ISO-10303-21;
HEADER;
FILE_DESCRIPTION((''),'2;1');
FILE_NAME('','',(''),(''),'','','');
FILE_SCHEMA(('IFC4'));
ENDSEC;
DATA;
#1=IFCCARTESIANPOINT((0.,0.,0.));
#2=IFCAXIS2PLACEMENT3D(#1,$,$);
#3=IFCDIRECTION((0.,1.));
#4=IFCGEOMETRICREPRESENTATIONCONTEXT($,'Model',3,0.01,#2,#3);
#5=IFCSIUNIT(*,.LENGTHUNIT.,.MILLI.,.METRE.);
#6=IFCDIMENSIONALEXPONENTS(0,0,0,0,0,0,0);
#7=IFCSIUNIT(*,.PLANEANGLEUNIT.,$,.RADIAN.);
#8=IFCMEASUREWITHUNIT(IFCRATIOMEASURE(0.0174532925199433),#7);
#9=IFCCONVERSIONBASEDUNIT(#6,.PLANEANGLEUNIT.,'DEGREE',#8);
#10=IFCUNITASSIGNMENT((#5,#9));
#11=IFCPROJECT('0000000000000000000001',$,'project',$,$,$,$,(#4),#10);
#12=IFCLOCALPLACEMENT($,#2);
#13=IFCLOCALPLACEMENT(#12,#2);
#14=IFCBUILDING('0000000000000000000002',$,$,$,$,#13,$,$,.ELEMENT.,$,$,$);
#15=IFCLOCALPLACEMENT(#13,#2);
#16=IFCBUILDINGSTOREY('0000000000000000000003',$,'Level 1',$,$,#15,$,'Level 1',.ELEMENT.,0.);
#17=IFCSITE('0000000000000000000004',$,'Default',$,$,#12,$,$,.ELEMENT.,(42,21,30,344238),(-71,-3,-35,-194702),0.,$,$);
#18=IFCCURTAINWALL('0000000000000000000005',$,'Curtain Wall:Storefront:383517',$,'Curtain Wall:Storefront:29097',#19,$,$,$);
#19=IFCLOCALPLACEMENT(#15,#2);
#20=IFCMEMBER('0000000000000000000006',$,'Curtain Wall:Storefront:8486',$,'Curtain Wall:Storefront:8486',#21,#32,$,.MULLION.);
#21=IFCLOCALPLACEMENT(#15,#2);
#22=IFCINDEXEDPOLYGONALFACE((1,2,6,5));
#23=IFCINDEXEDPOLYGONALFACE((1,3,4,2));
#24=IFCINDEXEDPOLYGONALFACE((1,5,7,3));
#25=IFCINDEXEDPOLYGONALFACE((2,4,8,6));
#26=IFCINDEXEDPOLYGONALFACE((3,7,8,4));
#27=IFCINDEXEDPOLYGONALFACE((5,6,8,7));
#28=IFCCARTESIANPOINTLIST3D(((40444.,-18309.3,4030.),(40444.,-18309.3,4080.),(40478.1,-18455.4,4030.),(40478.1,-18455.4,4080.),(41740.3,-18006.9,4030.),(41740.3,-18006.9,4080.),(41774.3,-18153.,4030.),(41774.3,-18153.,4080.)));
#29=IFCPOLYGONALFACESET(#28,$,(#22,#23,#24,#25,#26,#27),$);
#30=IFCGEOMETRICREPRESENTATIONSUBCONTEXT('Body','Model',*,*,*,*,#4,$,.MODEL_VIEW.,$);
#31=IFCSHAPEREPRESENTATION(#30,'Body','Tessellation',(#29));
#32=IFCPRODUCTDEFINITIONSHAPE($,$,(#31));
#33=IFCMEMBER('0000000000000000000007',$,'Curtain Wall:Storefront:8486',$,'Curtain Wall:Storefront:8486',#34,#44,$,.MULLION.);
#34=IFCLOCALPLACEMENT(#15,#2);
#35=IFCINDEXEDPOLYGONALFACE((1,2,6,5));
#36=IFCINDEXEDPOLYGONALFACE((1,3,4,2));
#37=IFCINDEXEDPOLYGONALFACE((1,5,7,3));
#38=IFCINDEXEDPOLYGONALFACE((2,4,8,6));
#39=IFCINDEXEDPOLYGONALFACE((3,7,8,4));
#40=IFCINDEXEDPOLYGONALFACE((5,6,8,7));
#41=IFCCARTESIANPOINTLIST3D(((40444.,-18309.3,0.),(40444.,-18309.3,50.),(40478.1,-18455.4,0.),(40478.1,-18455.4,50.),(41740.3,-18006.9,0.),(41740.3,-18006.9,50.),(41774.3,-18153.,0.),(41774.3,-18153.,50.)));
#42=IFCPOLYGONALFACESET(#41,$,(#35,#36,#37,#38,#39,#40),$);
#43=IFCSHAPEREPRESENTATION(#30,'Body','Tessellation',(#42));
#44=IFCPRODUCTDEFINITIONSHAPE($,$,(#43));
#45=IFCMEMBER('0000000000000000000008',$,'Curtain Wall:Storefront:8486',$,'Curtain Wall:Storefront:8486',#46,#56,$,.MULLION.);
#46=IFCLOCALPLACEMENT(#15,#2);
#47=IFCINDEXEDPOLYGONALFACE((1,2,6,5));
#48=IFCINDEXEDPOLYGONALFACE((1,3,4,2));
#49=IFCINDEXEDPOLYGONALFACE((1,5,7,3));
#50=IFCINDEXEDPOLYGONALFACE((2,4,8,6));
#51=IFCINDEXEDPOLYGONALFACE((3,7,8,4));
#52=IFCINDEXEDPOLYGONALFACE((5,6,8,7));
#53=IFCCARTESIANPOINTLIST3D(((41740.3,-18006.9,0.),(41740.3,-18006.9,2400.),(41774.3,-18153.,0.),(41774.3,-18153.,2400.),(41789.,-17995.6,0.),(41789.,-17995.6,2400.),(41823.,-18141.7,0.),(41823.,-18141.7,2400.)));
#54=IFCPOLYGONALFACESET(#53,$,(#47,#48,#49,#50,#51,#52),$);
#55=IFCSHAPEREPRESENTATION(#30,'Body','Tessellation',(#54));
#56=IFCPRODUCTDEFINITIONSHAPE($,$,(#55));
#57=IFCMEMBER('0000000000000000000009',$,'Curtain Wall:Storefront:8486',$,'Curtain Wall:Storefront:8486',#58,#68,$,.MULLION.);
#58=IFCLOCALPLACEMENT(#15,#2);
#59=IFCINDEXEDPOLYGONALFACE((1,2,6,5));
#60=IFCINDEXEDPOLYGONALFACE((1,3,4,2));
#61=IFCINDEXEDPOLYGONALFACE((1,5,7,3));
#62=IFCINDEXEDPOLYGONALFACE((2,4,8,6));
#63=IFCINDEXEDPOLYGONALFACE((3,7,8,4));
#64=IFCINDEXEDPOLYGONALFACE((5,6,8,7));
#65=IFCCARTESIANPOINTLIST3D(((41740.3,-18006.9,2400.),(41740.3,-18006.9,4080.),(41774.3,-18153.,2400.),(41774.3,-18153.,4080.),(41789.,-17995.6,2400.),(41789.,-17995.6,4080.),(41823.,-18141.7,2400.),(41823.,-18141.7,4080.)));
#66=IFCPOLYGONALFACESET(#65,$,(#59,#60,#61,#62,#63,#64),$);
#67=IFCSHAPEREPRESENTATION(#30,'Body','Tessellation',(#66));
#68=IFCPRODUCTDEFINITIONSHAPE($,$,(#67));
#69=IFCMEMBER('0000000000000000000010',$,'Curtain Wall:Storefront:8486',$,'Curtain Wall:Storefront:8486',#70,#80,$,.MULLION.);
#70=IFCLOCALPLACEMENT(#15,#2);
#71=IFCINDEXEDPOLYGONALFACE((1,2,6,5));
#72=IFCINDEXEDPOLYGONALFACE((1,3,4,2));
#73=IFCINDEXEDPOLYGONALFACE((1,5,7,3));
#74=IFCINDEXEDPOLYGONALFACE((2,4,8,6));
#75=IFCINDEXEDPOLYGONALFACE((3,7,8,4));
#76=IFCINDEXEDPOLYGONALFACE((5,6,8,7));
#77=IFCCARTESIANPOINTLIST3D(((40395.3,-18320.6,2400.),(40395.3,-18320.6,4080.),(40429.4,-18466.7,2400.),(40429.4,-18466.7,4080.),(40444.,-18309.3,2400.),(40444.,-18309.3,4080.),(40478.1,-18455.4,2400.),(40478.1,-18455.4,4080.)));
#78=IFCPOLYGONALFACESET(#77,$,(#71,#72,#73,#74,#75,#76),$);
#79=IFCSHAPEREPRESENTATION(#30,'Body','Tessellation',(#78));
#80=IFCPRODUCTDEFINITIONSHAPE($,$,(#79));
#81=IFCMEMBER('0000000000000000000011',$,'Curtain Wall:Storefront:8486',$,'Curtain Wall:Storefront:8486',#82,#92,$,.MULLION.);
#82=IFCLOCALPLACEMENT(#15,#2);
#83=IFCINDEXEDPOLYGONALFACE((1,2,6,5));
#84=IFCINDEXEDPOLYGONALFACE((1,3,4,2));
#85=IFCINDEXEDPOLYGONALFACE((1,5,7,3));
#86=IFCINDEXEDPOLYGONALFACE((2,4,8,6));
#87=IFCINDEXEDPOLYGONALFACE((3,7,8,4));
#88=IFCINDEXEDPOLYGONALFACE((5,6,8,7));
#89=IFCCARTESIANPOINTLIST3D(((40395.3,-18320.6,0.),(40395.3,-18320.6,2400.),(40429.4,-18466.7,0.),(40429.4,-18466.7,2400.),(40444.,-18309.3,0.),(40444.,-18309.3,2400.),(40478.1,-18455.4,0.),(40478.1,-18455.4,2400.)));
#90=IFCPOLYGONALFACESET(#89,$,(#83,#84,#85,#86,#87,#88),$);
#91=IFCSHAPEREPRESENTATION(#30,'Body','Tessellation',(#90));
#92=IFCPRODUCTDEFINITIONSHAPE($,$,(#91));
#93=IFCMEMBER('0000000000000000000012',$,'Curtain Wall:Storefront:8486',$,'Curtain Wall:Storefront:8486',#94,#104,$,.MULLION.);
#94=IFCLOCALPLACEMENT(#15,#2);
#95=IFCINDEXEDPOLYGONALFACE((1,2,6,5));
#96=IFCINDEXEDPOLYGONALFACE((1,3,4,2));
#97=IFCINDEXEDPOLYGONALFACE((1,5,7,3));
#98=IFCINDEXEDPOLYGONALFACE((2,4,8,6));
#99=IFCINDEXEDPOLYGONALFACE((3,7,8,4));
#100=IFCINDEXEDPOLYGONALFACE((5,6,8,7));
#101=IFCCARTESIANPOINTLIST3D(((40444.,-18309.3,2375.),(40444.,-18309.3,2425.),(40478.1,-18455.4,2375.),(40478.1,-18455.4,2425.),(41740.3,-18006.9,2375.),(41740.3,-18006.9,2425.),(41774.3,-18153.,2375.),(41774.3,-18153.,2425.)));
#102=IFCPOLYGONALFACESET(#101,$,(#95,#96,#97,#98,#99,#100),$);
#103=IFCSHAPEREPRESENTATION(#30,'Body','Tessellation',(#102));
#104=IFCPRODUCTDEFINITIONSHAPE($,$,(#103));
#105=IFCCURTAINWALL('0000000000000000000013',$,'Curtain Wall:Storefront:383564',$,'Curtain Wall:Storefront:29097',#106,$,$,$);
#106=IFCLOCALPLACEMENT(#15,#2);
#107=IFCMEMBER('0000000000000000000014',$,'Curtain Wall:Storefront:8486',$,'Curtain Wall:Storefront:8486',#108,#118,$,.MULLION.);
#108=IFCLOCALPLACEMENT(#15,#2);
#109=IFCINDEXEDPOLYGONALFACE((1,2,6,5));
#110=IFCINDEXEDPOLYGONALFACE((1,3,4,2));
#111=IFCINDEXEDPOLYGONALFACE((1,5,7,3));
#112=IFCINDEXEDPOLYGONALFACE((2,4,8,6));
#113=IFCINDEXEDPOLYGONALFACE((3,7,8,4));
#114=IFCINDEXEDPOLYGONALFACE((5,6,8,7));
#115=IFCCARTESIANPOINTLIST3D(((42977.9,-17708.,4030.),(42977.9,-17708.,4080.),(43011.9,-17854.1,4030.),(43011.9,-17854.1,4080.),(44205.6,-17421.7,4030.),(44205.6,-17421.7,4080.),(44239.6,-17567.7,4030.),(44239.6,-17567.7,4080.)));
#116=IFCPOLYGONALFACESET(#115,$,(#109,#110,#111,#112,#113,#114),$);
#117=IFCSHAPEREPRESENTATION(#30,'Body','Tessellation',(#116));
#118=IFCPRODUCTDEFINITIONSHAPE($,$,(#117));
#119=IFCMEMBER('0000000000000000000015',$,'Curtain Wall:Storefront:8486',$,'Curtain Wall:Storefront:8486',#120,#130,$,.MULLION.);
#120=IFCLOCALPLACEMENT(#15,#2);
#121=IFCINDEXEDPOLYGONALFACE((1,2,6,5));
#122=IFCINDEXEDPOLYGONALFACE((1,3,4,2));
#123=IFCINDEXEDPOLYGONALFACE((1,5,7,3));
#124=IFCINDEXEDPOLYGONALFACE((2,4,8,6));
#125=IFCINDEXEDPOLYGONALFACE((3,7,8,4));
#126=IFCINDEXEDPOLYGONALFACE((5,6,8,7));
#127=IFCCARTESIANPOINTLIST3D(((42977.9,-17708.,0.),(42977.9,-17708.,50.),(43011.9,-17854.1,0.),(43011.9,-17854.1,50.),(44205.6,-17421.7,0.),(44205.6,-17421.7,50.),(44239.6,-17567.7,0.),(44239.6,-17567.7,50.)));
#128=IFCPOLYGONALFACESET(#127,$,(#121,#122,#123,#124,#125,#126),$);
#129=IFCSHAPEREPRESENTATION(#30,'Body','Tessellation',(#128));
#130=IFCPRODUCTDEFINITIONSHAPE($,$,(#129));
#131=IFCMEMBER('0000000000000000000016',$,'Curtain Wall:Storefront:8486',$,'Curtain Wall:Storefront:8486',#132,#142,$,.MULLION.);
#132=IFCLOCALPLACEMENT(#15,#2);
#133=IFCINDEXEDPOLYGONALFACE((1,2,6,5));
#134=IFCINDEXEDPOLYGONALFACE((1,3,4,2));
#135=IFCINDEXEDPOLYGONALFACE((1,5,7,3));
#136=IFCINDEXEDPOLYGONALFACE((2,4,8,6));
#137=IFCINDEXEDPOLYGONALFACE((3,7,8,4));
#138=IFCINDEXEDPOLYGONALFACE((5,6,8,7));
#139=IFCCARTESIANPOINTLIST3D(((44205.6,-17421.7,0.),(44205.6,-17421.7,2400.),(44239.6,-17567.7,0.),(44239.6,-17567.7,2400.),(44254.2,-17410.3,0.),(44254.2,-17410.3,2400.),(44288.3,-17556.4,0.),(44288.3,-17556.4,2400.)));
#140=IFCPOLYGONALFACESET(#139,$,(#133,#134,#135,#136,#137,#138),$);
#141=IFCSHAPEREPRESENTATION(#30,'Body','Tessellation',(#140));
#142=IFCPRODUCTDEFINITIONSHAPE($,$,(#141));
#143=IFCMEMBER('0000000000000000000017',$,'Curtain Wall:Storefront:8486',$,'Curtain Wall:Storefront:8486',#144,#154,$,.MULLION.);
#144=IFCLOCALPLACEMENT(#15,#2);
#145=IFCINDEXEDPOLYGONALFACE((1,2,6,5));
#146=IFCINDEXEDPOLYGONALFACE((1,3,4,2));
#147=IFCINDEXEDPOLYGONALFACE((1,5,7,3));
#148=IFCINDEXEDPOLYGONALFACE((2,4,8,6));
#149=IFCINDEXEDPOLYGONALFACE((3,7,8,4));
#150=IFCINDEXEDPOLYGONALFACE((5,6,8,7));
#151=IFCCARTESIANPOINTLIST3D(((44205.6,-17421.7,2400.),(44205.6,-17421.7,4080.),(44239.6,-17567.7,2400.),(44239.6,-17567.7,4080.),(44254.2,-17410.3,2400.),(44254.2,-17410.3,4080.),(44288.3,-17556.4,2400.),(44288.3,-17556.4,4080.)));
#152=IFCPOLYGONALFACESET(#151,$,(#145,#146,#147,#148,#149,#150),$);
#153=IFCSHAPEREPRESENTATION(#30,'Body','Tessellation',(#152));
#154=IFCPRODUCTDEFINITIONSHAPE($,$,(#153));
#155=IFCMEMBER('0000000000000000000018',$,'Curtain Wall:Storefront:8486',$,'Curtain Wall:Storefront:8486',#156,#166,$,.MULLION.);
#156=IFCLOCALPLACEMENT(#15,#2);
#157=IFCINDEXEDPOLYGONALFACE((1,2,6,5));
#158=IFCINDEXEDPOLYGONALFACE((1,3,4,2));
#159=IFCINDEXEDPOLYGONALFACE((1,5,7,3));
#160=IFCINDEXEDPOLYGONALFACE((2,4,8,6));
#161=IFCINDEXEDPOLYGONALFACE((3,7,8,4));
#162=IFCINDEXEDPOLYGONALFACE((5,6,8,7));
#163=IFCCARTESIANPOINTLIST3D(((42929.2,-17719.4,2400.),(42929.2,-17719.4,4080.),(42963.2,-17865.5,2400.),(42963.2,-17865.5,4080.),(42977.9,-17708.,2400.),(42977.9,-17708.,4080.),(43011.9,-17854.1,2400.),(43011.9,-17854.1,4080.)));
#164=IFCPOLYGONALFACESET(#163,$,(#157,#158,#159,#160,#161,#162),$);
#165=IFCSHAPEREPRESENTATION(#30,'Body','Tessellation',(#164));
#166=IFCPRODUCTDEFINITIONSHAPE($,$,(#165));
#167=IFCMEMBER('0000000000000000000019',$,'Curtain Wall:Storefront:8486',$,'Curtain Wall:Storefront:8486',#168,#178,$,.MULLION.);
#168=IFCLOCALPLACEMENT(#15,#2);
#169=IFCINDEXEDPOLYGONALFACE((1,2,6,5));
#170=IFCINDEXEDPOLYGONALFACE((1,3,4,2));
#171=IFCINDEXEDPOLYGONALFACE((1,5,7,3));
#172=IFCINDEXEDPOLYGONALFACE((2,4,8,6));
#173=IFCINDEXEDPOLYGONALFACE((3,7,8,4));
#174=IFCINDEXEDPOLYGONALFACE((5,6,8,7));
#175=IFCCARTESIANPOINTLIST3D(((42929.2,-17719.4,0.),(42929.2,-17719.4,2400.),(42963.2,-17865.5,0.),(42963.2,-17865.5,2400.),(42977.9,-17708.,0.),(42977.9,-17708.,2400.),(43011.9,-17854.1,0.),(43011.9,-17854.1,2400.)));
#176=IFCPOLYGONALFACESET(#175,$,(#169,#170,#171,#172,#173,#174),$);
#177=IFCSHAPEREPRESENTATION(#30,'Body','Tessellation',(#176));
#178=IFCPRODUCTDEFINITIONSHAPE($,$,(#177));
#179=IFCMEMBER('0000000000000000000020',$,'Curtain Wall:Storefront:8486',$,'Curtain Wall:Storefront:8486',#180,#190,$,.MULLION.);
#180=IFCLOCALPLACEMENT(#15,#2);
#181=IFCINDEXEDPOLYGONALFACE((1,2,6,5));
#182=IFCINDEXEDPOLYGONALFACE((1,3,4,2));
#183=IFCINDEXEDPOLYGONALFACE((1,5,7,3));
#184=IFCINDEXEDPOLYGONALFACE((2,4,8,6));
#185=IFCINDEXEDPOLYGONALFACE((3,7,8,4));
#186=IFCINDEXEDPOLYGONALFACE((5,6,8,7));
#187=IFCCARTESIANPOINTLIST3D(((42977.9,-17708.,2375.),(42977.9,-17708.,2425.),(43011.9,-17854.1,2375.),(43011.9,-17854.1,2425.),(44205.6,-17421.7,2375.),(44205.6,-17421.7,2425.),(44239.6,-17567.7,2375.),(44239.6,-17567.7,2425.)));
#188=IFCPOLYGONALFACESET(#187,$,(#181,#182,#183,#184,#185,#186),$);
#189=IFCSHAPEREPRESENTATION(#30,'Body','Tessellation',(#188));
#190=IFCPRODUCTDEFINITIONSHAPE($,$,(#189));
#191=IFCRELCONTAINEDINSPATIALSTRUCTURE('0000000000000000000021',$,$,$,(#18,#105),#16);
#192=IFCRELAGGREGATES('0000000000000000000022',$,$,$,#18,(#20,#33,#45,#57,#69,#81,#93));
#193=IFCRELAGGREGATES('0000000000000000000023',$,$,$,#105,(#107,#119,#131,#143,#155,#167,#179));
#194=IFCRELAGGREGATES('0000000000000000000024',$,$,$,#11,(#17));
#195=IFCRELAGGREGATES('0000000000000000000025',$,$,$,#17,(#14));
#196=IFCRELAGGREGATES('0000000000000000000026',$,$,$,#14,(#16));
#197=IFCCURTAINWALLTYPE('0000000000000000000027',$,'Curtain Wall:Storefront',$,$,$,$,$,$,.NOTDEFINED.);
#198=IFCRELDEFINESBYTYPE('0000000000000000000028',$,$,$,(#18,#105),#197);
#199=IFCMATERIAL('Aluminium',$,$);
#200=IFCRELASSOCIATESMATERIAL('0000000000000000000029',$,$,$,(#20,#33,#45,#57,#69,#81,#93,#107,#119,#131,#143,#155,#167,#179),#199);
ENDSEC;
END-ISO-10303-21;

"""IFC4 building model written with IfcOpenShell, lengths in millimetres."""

from ifc_helpers import new_model, entity, si_unit, converted_unit, direction, frame, frame_2d, origin, place, context, subcontext, project, spatial, rectangle, extrude, material, type_object, element, aggregate, save


model = new_model("IFC4")

# Units and contexts
model_context = context("Model", 3, precision=0.01, world=origin(), true_north=direction((0.0, 1.0)))
body_context = subcontext(model_context, "Body", "Model", "MODEL_VIEW")
ifc_project = project(units=[si_unit("LENGTHUNIT", "METRE", prefix="MILLI"), converted_unit("PLANEANGLEUNIT", "DEGREE", entity("IfcRatioMeasure", 0.0174532925199433), si_unit("PLANEANGLEUNIT", "RADIAN"), dimensions=[0, 0, 0, 0, 0, 0, 0])], contexts=[model_context])

# Site, building, storey
site_placement = place(None, origin())
site = spatial("IfcSite", under=ifc_project, at=site_placement, Name="Default", CompositionType="ELEMENT", RefLatitude=(42, 21, 30, 344238), RefLongitude=(-71, -3, -35, -194702), RefElevation=0.0)
building_placement = place(site_placement, origin())
building = spatial("IfcBuilding", under=site, at=building_placement, CompositionType="ELEMENT")
storey_placement = place(building_placement, origin())
storey = spatial("IfcBuildingStorey", under=building, at=storey_placement, Name="Level 1", LongName="Level 1", CompositionType="ELEMENT", Elevation=0.0)

# Curtain walls, members
curtain_wall_type = type_object("IfcCurtainWallType", Name="Curtain Wall:Storefront", PredefinedType="NOTDEFINED")
curtain_wall_1_placement = place(storey_placement, origin())
curtain_wall_1 = element("IfcCurtainWall", 1, at=curtain_wall_1_placement, inside=storey, type_object=curtain_wall_type, Name="Curtain Wall:Storefront:383517", ObjectType="Curtain Wall:Storefront:29097")
ifc_material = material(Name="Aluminium")
member_1_placement = place(curtain_wall_1_placement, origin())
member_1 = element("IfcMember", 2, at=member_1_placement, material=ifc_material, Name="Curtain Wall:Storefront:8486", ObjectType="Curtain Wall:Storefront:8486", PredefinedType="MULLION", context=body_context, shape_type="SweptSolid", body=[
    extrude(rectangle(XDim=50.0, YDim=150.0, at=frame_2d((0.0, 0.0), x_axis=(1.0, 0.0))), frame((41757.3, -18080.0, 4055.0), z_axis=(-0.973861, -0.227145, 0.0), x_axis=(0.0, 0.0, -1.0)), (0.0, 0.0, 1.0), 1331.1),
])
member_2_placement = place(curtain_wall_1_placement, origin())
member_2 = element("IfcMember", 3, at=member_2_placement, material=ifc_material, Name="Curtain Wall:Storefront:8486", ObjectType="Curtain Wall:Storefront:8486", PredefinedType="MULLION", context=body_context, shape_type="SweptSolid", body=[
    extrude(rectangle(XDim=50.0, YDim=150.0, at=frame_2d((0.0, 0.0), x_axis=(1.0, 0.0))), frame((40461.0, -18382.3, 25.0), z_axis=(0.973861, 0.227145, 0.0), x_axis=(0.0, 0.0, -1.0)), (0.0, 0.0, 1.0), 1331.1),
])
member_3_placement = place(curtain_wall_1_placement, origin())
member_3 = element("IfcMember", 4, at=member_3_placement, material=ifc_material, Name="Curtain Wall:Storefront:8486", ObjectType="Curtain Wall:Storefront:8486", PredefinedType="MULLION", context=body_context, shape_type="SweptSolid", body=[
    extrude(rectangle(XDim=50.0, YDim=150.0, at=frame_2d((0.0, 0.0), x_axis=(1.0, 0.0))), frame((41781.7, -18074.3, 0.0), z_axis=(0.0, 0.0, 1.0), x_axis=(0.973861, 0.227145, 0.0)), (0.0, 0.0, 1.0), 2400.0),
])
member_4_placement = place(curtain_wall_1_placement, origin())
member_4 = element("IfcMember", 5, at=member_4_placement, material=ifc_material, Name="Curtain Wall:Storefront:8486", ObjectType="Curtain Wall:Storefront:8486", PredefinedType="MULLION", context=body_context, shape_type="SweptSolid", body=[
    extrude(rectangle(XDim=50.0, YDim=150.0, at=frame_2d((0.0, 0.0), x_axis=(1.0, 0.0))), frame((41781.7, -18074.3, 2400.0), z_axis=(0.0, 0.0, 1.0), x_axis=(0.973861, 0.227145, 0.0)), (0.0, 0.0, 1.0), 1680.0),
])
member_5_placement = place(curtain_wall_1_placement, origin())
member_5 = element("IfcMember", 6, at=member_5_placement, material=ifc_material, Name="Curtain Wall:Storefront:8486", ObjectType="Curtain Wall:Storefront:8486", PredefinedType="MULLION", context=body_context, shape_type="SweptSolid", body=[
    extrude(rectangle(XDim=150.0, YDim=50.0, at=frame_2d((0.0, 0.0), x_axis=(1.0, 0.0))), frame((40436.7, -18388.0, 4080.0), z_axis=(0.0, 0.0, -1.0), x_axis=(0.227145, -0.973861, 0.0)), (0.0, 0.0, 1.0), 1680.0),
])
member_6_placement = place(curtain_wall_1_placement, origin())
member_6 = element("IfcMember", 7, at=member_6_placement, material=ifc_material, Name="Curtain Wall:Storefront:8486", ObjectType="Curtain Wall:Storefront:8486", PredefinedType="MULLION", context=body_context, shape_type="SweptSolid", body=[
    extrude(rectangle(XDim=150.0, YDim=50.0, at=frame_2d((0.0, 0.0), x_axis=(1.0, 0.0))), frame((40436.7, -18388.0, 2400.0), z_axis=(0.0, 0.0, -1.0), x_axis=(0.227145, -0.973861, 0.0)), (0.0, 0.0, 1.0), 2400.0),
])
member_7_placement = place(curtain_wall_1_placement, origin())
member_7 = element("IfcMember", 8, at=member_7_placement, material=ifc_material, Name="Curtain Wall:Storefront:8486", ObjectType="Curtain Wall:Storefront:8486", PredefinedType="MULLION", context=body_context, shape_type="SweptSolid", body=[
    extrude(rectangle(XDim=50.0, YDim=150.0, at=frame_2d((0.0, 0.0), x_axis=(1.0, 0.0))), frame((41757.3, -18080.0, 2400.0), z_axis=(-0.973861, -0.227145, 0.0), x_axis=(0.0, 0.0, -1.0)), (0.0, 0.0, 1.0), 1331.1),
])
aggregate(curtain_wall_1, [member_1, member_2, member_3, member_4, member_5, member_6, member_7])
curtain_wall_2_placement = place(storey_placement, origin())
curtain_wall_2 = element("IfcCurtainWall", 9, at=curtain_wall_2_placement, inside=storey, type_object=curtain_wall_type, Name="Curtain Wall:Storefront:383564", ObjectType="Curtain Wall:Storefront:29097")
member_8_placement = place(curtain_wall_2_placement, origin())
member_8 = element("IfcMember", 10, at=member_8_placement, material=ifc_material, Name="Curtain Wall:Storefront:8486", ObjectType="Curtain Wall:Storefront:8486", PredefinedType="MULLION", context=body_context, shape_type="SweptSolid", body=[
    extrude(rectangle(XDim=50.0, YDim=150.0, at=frame_2d((0.0, 0.0), x_axis=(1.0, 0.0))), frame((44222.6, -17494.7, 4055.0), z_axis=(-0.973861, -0.227145, 0.0), x_axis=(0.0, 0.0, -1.0)), (0.0, 0.0, 1.0), 1260.7),
])
member_9_placement = place(curtain_wall_2_placement, origin())
member_9 = element("IfcMember", 11, at=member_9_placement, material=ifc_material, Name="Curtain Wall:Storefront:8486", ObjectType="Curtain Wall:Storefront:8486", PredefinedType="MULLION", context=body_context, shape_type="SweptSolid", body=[
    extrude(rectangle(XDim=50.0, YDim=150.0, at=frame_2d((0.0, 0.0), x_axis=(1.0, 0.0))), frame((42994.9, -17781.1, 25.0), z_axis=(0.973861, 0.227145, 0.0), x_axis=(0.0, 0.0, -1.0)), (0.0, 0.0, 1.0), 1260.7),
])
member_10_placement = place(curtain_wall_2_placement, origin())
member_10 = element("IfcMember", 12, at=member_10_placement, material=ifc_material, Name="Curtain Wall:Storefront:8486", ObjectType="Curtain Wall:Storefront:8486", PredefinedType="MULLION", context=body_context, shape_type="SweptSolid", body=[
    extrude(rectangle(XDim=50.0, YDim=150.0, at=frame_2d((0.0, 0.0), x_axis=(1.0, 0.0))), frame((44246.9, -17489.0, 0.0), z_axis=(0.0, 0.0, 1.0), x_axis=(0.973861, 0.227145, 0.0)), (0.0, 0.0, 1.0), 2400.0),
])
member_11_placement = place(curtain_wall_2_placement, origin())
member_11 = element("IfcMember", 13, at=member_11_placement, material=ifc_material, Name="Curtain Wall:Storefront:8486", ObjectType="Curtain Wall:Storefront:8486", PredefinedType="MULLION", context=body_context, shape_type="SweptSolid", body=[
    extrude(rectangle(XDim=50.0, YDim=150.0, at=frame_2d((0.0, 0.0), x_axis=(1.0, 0.0))), frame((44246.9, -17489.0, 2400.0), z_axis=(0.0, 0.0, 1.0), x_axis=(0.973861, 0.227145, 0.0)), (0.0, 0.0, 1.0), 1680.0),
])
member_12_placement = place(curtain_wall_2_placement, origin())
member_12 = element("IfcMember", 14, at=member_12_placement, material=ifc_material, Name="Curtain Wall:Storefront:8486", ObjectType="Curtain Wall:Storefront:8486", PredefinedType="MULLION", context=body_context, shape_type="SweptSolid", body=[
    extrude(rectangle(XDim=150.0, YDim=50.0, at=frame_2d((0.0, 0.0), x_axis=(1.0, 0.0))), frame((42970.5, -17786.7, 4080.0), z_axis=(0.0, 0.0, -1.0), x_axis=(0.227145, -0.973861, 0.0)), (0.0, 0.0, 1.0), 1680.0),
])
member_13_placement = place(curtain_wall_2_placement, origin())
member_13 = element("IfcMember", 15, at=member_13_placement, material=ifc_material, Name="Curtain Wall:Storefront:8486", ObjectType="Curtain Wall:Storefront:8486", PredefinedType="MULLION", context=body_context, shape_type="SweptSolid", body=[
    extrude(rectangle(XDim=150.0, YDim=50.0, at=frame_2d((0.0, 0.0), x_axis=(1.0, 0.0))), frame((42970.5, -17786.7, 2400.0), z_axis=(0.0, 0.0, -1.0), x_axis=(0.227145, -0.973861, 0.0)), (0.0, 0.0, 1.0), 2400.0),
])
member_14_placement = place(curtain_wall_2_placement, origin())
member_14 = element("IfcMember", 16, at=member_14_placement, material=ifc_material, Name="Curtain Wall:Storefront:8486", ObjectType="Curtain Wall:Storefront:8486", PredefinedType="MULLION", context=body_context, shape_type="SweptSolid", body=[
    extrude(rectangle(XDim=50.0, YDim=150.0, at=frame_2d((0.0, 0.0), x_axis=(1.0, 0.0))), frame((44222.6, -17494.7, 2400.0), z_axis=(-0.973861, -0.227145, 0.0), x_axis=(0.0, 0.0, -1.0)), (0.0, 0.0, 1.0), 1260.7),
])
aggregate(curtain_wall_2, [member_8, member_9, member_10, member_11, member_12, member_13, member_14])

save(model, "model.ifc")
